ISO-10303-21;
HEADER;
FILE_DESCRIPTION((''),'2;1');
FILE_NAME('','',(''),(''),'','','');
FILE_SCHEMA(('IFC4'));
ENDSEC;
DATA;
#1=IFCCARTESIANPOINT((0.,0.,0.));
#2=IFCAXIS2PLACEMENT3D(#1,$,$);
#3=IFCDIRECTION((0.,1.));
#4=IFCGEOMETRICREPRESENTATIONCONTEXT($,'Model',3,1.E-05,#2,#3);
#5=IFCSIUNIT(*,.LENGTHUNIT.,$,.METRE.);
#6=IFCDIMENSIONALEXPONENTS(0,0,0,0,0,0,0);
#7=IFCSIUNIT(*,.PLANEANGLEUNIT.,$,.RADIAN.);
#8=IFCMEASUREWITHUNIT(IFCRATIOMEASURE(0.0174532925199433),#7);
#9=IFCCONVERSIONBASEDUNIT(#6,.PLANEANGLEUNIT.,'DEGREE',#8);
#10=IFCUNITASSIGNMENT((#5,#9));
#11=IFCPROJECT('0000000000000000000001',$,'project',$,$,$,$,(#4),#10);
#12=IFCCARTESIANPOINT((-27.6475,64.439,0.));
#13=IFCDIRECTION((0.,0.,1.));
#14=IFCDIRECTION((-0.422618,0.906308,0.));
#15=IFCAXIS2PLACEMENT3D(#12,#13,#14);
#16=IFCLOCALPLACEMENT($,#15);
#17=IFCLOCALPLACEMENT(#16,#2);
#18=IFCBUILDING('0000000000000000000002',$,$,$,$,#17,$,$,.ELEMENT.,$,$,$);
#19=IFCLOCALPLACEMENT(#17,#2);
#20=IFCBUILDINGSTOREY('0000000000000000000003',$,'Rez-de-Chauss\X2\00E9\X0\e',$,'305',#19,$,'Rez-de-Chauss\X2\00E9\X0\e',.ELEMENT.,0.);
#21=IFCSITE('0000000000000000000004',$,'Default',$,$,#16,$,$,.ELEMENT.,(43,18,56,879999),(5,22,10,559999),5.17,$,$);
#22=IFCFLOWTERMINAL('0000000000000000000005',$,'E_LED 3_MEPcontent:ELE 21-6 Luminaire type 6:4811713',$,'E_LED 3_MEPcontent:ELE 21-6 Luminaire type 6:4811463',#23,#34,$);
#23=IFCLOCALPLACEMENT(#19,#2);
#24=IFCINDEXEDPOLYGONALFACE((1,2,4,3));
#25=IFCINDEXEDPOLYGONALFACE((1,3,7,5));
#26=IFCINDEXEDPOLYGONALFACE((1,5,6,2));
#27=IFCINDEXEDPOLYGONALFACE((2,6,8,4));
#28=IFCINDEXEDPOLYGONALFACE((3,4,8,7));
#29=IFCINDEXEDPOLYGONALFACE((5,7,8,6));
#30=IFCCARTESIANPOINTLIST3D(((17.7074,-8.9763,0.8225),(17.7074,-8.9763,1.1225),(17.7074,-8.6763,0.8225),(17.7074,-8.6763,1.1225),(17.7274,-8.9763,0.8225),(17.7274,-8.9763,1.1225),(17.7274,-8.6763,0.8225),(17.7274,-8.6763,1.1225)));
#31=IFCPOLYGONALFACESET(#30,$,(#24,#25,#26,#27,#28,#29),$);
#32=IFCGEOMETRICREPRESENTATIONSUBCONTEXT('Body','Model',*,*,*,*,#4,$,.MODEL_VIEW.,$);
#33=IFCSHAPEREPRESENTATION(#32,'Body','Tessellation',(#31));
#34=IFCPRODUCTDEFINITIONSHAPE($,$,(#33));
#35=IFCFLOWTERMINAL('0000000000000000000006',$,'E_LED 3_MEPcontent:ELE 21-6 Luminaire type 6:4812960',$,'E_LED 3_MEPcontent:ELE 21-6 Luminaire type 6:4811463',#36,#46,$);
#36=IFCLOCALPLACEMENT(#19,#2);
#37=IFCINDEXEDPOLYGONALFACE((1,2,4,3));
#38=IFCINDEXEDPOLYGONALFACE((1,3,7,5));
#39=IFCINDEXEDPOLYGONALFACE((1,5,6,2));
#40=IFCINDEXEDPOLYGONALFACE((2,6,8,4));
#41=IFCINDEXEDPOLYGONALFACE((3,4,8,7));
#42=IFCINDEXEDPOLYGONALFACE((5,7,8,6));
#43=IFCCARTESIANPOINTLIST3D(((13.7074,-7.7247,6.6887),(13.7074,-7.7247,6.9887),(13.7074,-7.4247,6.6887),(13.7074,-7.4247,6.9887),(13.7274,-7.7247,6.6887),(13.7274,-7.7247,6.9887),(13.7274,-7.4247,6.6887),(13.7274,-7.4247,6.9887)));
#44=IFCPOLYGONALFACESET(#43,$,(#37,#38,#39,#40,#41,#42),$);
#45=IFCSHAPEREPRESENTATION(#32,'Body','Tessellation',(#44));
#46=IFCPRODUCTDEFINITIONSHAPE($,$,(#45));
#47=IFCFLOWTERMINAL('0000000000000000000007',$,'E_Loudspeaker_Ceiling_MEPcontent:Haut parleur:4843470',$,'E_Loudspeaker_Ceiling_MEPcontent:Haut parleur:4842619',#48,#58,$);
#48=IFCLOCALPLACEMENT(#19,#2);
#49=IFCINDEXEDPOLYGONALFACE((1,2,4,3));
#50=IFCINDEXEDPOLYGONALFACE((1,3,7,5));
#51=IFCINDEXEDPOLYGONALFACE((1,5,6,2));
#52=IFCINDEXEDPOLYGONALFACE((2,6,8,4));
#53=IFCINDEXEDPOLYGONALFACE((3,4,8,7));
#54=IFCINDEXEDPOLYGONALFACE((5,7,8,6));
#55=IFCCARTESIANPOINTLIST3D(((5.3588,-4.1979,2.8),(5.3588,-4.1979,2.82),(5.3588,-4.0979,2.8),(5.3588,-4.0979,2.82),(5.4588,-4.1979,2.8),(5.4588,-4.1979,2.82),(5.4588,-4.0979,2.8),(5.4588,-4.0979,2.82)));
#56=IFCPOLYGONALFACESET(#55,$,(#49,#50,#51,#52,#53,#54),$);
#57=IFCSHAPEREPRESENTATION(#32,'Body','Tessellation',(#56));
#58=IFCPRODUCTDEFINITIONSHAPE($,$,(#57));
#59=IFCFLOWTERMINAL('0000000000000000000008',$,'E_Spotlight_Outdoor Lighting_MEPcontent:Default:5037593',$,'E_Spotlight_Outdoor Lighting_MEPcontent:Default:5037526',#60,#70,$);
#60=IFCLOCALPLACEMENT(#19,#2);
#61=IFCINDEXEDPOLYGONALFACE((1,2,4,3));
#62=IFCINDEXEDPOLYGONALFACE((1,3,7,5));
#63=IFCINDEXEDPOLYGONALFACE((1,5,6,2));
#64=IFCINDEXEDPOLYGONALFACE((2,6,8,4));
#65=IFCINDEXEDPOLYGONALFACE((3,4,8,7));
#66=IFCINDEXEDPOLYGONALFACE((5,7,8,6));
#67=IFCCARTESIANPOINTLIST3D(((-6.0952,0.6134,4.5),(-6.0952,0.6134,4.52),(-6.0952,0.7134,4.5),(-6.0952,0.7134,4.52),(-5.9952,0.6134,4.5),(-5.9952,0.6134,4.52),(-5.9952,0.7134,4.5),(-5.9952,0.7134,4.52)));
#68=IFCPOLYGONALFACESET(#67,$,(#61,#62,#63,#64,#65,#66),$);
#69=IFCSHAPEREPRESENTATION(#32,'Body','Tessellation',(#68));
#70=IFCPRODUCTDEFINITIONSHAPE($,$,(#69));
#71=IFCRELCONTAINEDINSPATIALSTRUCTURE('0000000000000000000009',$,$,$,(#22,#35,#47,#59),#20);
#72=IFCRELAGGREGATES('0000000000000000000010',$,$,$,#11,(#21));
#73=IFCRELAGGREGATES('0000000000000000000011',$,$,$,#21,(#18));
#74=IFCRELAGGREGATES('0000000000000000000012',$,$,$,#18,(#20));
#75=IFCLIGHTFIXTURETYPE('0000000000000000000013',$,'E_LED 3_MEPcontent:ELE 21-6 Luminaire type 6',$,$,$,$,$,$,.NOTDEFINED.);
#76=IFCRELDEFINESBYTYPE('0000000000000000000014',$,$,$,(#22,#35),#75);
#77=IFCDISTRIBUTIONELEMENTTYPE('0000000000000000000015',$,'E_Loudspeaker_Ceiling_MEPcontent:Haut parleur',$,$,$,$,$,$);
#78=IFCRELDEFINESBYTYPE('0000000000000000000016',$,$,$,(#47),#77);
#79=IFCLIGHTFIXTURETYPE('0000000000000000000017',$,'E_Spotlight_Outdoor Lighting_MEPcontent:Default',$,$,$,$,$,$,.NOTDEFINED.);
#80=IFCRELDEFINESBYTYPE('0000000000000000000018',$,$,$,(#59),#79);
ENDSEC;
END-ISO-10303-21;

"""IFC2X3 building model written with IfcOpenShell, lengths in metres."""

from ifc_helpers import new_model, entity, si_unit, converted_unit, direction, frame, origin, origin_2d_with_axis, place, context, subcontext, project, spatial, rectangle, extrude, source, transform, mapped, type_object, type_shapes, element, save


model = new_model("IFC2X3")

# Units and contexts
model_context = context("Model", 3, precision=1e-05, world=origin(), true_north=direction((0.0, 1.0)))
body_context = subcontext(model_context, "Body", "Model", "MODEL_VIEW")
ifc_project = project(units=[si_unit("LENGTHUNIT", "METRE"), converted_unit("PLANEANGLEUNIT", "DEGREE", entity("IfcRatioMeasure", 0.0174532925199433), si_unit("PLANEANGLEUNIT", "RADIAN"), dimensions=[0, 0, 0, 0, 0, 0, 0])], contexts=[model_context])

# Site, building, storey
site_placement = place(None, frame((-27.6475, 64.439, 0.0), z_axis=(0.0, 0.0, 1.0), x_axis=(-0.422618, 0.906308, 0.0)))
site = spatial("IfcSite", under=ifc_project, at=site_placement, Name="Default", CompositionType="ELEMENT", RefLatitude=(43, 18, 56, 879999), RefLongitude=(5, 22, 10, 559999), RefElevation=5.17)
building_placement = place(site_placement, origin())
building = spatial("IfcBuilding", under=site, at=building_placement, CompositionType="ELEMENT")
storey_placement = place(building_placement, origin())
storey = spatial("IfcBuildingStorey", under=building, at=storey_placement, Name="Rez-de-Chaussée", ObjectType="305", LongName="Rez-de-Chaussée", CompositionType="ELEMENT", Elevation=0.0)

# Flow terminals
light_fixture_type_1 = type_object("IfcLightFixtureType", Name="E_LED 3_MEPcontent:ELE 21-6 Luminaire type 6", PredefinedType="NOTDEFINED")
shared_shape_1 = source(origin(), body_context, "Body", "SweptSolid", [
    extrude(rectangle(XDim=0.02, YDim=0.3, at=origin_2d_with_axis()), frame((0.0, 0.01, -0.15), z_axis=(0.0, 0.0, 1.0), x_axis=(0.0, -1.0, 0.0)), (0.0, 0.0, 1.0), 0.3),
])
type_shapes(light_fixture_type_1, [shared_shape_1])
for number, where, z_axis, x_axis, name in (
    (1, (17.7074, -8.8263, 0.9725), (0.0, 0.0, 1.0), (0.0, -1.0, 0.0), "E_LED 3_MEPcontent:ELE 21-6 Luminaire type 6:4811713"),
    (2, (13.7074, -7.5747, 6.8387), (0.0, 0.0, 1.0), (0.0, -1.0, 0.0), "E_LED 3_MEPcontent:ELE 21-6 Luminaire type 6:4812960"),
):
    element("IfcFlowTerminal", number, at=place(storey_placement, frame(where, z_axis=z_axis, x_axis=x_axis)), inside=storey, type_object=light_fixture_type_1, Name=name, ObjectType="E_LED 3_MEPcontent:ELE 21-6 Luminaire type 6:4811463", context=body_context, shape_type="MappedRepresentation", body=[
        mapped(shared_shape_1, transform((0.0, 0.0, 0.0), scale=1.0)),
    ])
distribution_element_type = type_object("IfcDistributionElementType", Name="E_Loudspeaker_Ceiling_MEPcontent:Haut parleur")
shared_shape_2 = source(origin(), body_context, "Body", "SweptSolid", [
    extrude(rectangle(XDim=0.1, YDim=0.1, at=origin_2d_with_axis()), frame((0.0, 0.0, 0.0), z_axis=(0.0, 0.0, 1.0), x_axis=(0.0, -1.0, 0.0)), (0.0, 0.0, 1.0), 0.02),
])
type_shapes(distribution_element_type, [shared_shape_2])
flow_terminal_1_placement = place(storey_placement, frame((5.4088, -4.1479, 2.8), z_axis=(0.0, 0.0, 1.0), x_axis=(0.0, -1.0, 0.0)))
element("IfcFlowTerminal", 3, at=flow_terminal_1_placement, inside=storey, type_object=distribution_element_type, Name="E_Loudspeaker_Ceiling_MEPcontent:Haut parleur:4843470", ObjectType="E_Loudspeaker_Ceiling_MEPcontent:Haut parleur:4842619", context=body_context, shape_type="MappedRepresentation", body=[
    mapped(shared_shape_2, transform((0.0, 0.0, 0.0), scale=1.0)),
])
light_fixture_type_2 = type_object("IfcLightFixtureType", Name="E_Spotlight_Outdoor Lighting_MEPcontent:Default", PredefinedType="NOTDEFINED")
shared_shape_3 = source(origin(), body_context, "Body", "SweptSolid", [
    extrude(rectangle(XDim=0.1, YDim=0.1, at=origin_2d_with_axis()), frame((0.0, 0.0, 0.0), z_axis=(0.0, 0.0, 1.0), x_axis=(0.0, -1.0, 0.0)), (0.0, 0.0, 1.0), 0.02),
])
type_shapes(light_fixture_type_2, [shared_shape_3])
flow_terminal_2_placement = place(storey_placement, frame((-6.0452, 0.6634, 4.5)))
element("IfcFlowTerminal", 4, at=flow_terminal_2_placement, inside=storey, type_object=light_fixture_type_2, Name="E_Spotlight_Outdoor Lighting_MEPcontent:Default:5037593", ObjectType="E_Spotlight_Outdoor Lighting_MEPcontent:Default:5037526", context=body_context, shape_type="MappedRepresentation", body=[
    mapped(shared_shape_3, transform((0.0, 0.0, 0.0), scale=1.0)),
])

save(model, "model.ifc")
